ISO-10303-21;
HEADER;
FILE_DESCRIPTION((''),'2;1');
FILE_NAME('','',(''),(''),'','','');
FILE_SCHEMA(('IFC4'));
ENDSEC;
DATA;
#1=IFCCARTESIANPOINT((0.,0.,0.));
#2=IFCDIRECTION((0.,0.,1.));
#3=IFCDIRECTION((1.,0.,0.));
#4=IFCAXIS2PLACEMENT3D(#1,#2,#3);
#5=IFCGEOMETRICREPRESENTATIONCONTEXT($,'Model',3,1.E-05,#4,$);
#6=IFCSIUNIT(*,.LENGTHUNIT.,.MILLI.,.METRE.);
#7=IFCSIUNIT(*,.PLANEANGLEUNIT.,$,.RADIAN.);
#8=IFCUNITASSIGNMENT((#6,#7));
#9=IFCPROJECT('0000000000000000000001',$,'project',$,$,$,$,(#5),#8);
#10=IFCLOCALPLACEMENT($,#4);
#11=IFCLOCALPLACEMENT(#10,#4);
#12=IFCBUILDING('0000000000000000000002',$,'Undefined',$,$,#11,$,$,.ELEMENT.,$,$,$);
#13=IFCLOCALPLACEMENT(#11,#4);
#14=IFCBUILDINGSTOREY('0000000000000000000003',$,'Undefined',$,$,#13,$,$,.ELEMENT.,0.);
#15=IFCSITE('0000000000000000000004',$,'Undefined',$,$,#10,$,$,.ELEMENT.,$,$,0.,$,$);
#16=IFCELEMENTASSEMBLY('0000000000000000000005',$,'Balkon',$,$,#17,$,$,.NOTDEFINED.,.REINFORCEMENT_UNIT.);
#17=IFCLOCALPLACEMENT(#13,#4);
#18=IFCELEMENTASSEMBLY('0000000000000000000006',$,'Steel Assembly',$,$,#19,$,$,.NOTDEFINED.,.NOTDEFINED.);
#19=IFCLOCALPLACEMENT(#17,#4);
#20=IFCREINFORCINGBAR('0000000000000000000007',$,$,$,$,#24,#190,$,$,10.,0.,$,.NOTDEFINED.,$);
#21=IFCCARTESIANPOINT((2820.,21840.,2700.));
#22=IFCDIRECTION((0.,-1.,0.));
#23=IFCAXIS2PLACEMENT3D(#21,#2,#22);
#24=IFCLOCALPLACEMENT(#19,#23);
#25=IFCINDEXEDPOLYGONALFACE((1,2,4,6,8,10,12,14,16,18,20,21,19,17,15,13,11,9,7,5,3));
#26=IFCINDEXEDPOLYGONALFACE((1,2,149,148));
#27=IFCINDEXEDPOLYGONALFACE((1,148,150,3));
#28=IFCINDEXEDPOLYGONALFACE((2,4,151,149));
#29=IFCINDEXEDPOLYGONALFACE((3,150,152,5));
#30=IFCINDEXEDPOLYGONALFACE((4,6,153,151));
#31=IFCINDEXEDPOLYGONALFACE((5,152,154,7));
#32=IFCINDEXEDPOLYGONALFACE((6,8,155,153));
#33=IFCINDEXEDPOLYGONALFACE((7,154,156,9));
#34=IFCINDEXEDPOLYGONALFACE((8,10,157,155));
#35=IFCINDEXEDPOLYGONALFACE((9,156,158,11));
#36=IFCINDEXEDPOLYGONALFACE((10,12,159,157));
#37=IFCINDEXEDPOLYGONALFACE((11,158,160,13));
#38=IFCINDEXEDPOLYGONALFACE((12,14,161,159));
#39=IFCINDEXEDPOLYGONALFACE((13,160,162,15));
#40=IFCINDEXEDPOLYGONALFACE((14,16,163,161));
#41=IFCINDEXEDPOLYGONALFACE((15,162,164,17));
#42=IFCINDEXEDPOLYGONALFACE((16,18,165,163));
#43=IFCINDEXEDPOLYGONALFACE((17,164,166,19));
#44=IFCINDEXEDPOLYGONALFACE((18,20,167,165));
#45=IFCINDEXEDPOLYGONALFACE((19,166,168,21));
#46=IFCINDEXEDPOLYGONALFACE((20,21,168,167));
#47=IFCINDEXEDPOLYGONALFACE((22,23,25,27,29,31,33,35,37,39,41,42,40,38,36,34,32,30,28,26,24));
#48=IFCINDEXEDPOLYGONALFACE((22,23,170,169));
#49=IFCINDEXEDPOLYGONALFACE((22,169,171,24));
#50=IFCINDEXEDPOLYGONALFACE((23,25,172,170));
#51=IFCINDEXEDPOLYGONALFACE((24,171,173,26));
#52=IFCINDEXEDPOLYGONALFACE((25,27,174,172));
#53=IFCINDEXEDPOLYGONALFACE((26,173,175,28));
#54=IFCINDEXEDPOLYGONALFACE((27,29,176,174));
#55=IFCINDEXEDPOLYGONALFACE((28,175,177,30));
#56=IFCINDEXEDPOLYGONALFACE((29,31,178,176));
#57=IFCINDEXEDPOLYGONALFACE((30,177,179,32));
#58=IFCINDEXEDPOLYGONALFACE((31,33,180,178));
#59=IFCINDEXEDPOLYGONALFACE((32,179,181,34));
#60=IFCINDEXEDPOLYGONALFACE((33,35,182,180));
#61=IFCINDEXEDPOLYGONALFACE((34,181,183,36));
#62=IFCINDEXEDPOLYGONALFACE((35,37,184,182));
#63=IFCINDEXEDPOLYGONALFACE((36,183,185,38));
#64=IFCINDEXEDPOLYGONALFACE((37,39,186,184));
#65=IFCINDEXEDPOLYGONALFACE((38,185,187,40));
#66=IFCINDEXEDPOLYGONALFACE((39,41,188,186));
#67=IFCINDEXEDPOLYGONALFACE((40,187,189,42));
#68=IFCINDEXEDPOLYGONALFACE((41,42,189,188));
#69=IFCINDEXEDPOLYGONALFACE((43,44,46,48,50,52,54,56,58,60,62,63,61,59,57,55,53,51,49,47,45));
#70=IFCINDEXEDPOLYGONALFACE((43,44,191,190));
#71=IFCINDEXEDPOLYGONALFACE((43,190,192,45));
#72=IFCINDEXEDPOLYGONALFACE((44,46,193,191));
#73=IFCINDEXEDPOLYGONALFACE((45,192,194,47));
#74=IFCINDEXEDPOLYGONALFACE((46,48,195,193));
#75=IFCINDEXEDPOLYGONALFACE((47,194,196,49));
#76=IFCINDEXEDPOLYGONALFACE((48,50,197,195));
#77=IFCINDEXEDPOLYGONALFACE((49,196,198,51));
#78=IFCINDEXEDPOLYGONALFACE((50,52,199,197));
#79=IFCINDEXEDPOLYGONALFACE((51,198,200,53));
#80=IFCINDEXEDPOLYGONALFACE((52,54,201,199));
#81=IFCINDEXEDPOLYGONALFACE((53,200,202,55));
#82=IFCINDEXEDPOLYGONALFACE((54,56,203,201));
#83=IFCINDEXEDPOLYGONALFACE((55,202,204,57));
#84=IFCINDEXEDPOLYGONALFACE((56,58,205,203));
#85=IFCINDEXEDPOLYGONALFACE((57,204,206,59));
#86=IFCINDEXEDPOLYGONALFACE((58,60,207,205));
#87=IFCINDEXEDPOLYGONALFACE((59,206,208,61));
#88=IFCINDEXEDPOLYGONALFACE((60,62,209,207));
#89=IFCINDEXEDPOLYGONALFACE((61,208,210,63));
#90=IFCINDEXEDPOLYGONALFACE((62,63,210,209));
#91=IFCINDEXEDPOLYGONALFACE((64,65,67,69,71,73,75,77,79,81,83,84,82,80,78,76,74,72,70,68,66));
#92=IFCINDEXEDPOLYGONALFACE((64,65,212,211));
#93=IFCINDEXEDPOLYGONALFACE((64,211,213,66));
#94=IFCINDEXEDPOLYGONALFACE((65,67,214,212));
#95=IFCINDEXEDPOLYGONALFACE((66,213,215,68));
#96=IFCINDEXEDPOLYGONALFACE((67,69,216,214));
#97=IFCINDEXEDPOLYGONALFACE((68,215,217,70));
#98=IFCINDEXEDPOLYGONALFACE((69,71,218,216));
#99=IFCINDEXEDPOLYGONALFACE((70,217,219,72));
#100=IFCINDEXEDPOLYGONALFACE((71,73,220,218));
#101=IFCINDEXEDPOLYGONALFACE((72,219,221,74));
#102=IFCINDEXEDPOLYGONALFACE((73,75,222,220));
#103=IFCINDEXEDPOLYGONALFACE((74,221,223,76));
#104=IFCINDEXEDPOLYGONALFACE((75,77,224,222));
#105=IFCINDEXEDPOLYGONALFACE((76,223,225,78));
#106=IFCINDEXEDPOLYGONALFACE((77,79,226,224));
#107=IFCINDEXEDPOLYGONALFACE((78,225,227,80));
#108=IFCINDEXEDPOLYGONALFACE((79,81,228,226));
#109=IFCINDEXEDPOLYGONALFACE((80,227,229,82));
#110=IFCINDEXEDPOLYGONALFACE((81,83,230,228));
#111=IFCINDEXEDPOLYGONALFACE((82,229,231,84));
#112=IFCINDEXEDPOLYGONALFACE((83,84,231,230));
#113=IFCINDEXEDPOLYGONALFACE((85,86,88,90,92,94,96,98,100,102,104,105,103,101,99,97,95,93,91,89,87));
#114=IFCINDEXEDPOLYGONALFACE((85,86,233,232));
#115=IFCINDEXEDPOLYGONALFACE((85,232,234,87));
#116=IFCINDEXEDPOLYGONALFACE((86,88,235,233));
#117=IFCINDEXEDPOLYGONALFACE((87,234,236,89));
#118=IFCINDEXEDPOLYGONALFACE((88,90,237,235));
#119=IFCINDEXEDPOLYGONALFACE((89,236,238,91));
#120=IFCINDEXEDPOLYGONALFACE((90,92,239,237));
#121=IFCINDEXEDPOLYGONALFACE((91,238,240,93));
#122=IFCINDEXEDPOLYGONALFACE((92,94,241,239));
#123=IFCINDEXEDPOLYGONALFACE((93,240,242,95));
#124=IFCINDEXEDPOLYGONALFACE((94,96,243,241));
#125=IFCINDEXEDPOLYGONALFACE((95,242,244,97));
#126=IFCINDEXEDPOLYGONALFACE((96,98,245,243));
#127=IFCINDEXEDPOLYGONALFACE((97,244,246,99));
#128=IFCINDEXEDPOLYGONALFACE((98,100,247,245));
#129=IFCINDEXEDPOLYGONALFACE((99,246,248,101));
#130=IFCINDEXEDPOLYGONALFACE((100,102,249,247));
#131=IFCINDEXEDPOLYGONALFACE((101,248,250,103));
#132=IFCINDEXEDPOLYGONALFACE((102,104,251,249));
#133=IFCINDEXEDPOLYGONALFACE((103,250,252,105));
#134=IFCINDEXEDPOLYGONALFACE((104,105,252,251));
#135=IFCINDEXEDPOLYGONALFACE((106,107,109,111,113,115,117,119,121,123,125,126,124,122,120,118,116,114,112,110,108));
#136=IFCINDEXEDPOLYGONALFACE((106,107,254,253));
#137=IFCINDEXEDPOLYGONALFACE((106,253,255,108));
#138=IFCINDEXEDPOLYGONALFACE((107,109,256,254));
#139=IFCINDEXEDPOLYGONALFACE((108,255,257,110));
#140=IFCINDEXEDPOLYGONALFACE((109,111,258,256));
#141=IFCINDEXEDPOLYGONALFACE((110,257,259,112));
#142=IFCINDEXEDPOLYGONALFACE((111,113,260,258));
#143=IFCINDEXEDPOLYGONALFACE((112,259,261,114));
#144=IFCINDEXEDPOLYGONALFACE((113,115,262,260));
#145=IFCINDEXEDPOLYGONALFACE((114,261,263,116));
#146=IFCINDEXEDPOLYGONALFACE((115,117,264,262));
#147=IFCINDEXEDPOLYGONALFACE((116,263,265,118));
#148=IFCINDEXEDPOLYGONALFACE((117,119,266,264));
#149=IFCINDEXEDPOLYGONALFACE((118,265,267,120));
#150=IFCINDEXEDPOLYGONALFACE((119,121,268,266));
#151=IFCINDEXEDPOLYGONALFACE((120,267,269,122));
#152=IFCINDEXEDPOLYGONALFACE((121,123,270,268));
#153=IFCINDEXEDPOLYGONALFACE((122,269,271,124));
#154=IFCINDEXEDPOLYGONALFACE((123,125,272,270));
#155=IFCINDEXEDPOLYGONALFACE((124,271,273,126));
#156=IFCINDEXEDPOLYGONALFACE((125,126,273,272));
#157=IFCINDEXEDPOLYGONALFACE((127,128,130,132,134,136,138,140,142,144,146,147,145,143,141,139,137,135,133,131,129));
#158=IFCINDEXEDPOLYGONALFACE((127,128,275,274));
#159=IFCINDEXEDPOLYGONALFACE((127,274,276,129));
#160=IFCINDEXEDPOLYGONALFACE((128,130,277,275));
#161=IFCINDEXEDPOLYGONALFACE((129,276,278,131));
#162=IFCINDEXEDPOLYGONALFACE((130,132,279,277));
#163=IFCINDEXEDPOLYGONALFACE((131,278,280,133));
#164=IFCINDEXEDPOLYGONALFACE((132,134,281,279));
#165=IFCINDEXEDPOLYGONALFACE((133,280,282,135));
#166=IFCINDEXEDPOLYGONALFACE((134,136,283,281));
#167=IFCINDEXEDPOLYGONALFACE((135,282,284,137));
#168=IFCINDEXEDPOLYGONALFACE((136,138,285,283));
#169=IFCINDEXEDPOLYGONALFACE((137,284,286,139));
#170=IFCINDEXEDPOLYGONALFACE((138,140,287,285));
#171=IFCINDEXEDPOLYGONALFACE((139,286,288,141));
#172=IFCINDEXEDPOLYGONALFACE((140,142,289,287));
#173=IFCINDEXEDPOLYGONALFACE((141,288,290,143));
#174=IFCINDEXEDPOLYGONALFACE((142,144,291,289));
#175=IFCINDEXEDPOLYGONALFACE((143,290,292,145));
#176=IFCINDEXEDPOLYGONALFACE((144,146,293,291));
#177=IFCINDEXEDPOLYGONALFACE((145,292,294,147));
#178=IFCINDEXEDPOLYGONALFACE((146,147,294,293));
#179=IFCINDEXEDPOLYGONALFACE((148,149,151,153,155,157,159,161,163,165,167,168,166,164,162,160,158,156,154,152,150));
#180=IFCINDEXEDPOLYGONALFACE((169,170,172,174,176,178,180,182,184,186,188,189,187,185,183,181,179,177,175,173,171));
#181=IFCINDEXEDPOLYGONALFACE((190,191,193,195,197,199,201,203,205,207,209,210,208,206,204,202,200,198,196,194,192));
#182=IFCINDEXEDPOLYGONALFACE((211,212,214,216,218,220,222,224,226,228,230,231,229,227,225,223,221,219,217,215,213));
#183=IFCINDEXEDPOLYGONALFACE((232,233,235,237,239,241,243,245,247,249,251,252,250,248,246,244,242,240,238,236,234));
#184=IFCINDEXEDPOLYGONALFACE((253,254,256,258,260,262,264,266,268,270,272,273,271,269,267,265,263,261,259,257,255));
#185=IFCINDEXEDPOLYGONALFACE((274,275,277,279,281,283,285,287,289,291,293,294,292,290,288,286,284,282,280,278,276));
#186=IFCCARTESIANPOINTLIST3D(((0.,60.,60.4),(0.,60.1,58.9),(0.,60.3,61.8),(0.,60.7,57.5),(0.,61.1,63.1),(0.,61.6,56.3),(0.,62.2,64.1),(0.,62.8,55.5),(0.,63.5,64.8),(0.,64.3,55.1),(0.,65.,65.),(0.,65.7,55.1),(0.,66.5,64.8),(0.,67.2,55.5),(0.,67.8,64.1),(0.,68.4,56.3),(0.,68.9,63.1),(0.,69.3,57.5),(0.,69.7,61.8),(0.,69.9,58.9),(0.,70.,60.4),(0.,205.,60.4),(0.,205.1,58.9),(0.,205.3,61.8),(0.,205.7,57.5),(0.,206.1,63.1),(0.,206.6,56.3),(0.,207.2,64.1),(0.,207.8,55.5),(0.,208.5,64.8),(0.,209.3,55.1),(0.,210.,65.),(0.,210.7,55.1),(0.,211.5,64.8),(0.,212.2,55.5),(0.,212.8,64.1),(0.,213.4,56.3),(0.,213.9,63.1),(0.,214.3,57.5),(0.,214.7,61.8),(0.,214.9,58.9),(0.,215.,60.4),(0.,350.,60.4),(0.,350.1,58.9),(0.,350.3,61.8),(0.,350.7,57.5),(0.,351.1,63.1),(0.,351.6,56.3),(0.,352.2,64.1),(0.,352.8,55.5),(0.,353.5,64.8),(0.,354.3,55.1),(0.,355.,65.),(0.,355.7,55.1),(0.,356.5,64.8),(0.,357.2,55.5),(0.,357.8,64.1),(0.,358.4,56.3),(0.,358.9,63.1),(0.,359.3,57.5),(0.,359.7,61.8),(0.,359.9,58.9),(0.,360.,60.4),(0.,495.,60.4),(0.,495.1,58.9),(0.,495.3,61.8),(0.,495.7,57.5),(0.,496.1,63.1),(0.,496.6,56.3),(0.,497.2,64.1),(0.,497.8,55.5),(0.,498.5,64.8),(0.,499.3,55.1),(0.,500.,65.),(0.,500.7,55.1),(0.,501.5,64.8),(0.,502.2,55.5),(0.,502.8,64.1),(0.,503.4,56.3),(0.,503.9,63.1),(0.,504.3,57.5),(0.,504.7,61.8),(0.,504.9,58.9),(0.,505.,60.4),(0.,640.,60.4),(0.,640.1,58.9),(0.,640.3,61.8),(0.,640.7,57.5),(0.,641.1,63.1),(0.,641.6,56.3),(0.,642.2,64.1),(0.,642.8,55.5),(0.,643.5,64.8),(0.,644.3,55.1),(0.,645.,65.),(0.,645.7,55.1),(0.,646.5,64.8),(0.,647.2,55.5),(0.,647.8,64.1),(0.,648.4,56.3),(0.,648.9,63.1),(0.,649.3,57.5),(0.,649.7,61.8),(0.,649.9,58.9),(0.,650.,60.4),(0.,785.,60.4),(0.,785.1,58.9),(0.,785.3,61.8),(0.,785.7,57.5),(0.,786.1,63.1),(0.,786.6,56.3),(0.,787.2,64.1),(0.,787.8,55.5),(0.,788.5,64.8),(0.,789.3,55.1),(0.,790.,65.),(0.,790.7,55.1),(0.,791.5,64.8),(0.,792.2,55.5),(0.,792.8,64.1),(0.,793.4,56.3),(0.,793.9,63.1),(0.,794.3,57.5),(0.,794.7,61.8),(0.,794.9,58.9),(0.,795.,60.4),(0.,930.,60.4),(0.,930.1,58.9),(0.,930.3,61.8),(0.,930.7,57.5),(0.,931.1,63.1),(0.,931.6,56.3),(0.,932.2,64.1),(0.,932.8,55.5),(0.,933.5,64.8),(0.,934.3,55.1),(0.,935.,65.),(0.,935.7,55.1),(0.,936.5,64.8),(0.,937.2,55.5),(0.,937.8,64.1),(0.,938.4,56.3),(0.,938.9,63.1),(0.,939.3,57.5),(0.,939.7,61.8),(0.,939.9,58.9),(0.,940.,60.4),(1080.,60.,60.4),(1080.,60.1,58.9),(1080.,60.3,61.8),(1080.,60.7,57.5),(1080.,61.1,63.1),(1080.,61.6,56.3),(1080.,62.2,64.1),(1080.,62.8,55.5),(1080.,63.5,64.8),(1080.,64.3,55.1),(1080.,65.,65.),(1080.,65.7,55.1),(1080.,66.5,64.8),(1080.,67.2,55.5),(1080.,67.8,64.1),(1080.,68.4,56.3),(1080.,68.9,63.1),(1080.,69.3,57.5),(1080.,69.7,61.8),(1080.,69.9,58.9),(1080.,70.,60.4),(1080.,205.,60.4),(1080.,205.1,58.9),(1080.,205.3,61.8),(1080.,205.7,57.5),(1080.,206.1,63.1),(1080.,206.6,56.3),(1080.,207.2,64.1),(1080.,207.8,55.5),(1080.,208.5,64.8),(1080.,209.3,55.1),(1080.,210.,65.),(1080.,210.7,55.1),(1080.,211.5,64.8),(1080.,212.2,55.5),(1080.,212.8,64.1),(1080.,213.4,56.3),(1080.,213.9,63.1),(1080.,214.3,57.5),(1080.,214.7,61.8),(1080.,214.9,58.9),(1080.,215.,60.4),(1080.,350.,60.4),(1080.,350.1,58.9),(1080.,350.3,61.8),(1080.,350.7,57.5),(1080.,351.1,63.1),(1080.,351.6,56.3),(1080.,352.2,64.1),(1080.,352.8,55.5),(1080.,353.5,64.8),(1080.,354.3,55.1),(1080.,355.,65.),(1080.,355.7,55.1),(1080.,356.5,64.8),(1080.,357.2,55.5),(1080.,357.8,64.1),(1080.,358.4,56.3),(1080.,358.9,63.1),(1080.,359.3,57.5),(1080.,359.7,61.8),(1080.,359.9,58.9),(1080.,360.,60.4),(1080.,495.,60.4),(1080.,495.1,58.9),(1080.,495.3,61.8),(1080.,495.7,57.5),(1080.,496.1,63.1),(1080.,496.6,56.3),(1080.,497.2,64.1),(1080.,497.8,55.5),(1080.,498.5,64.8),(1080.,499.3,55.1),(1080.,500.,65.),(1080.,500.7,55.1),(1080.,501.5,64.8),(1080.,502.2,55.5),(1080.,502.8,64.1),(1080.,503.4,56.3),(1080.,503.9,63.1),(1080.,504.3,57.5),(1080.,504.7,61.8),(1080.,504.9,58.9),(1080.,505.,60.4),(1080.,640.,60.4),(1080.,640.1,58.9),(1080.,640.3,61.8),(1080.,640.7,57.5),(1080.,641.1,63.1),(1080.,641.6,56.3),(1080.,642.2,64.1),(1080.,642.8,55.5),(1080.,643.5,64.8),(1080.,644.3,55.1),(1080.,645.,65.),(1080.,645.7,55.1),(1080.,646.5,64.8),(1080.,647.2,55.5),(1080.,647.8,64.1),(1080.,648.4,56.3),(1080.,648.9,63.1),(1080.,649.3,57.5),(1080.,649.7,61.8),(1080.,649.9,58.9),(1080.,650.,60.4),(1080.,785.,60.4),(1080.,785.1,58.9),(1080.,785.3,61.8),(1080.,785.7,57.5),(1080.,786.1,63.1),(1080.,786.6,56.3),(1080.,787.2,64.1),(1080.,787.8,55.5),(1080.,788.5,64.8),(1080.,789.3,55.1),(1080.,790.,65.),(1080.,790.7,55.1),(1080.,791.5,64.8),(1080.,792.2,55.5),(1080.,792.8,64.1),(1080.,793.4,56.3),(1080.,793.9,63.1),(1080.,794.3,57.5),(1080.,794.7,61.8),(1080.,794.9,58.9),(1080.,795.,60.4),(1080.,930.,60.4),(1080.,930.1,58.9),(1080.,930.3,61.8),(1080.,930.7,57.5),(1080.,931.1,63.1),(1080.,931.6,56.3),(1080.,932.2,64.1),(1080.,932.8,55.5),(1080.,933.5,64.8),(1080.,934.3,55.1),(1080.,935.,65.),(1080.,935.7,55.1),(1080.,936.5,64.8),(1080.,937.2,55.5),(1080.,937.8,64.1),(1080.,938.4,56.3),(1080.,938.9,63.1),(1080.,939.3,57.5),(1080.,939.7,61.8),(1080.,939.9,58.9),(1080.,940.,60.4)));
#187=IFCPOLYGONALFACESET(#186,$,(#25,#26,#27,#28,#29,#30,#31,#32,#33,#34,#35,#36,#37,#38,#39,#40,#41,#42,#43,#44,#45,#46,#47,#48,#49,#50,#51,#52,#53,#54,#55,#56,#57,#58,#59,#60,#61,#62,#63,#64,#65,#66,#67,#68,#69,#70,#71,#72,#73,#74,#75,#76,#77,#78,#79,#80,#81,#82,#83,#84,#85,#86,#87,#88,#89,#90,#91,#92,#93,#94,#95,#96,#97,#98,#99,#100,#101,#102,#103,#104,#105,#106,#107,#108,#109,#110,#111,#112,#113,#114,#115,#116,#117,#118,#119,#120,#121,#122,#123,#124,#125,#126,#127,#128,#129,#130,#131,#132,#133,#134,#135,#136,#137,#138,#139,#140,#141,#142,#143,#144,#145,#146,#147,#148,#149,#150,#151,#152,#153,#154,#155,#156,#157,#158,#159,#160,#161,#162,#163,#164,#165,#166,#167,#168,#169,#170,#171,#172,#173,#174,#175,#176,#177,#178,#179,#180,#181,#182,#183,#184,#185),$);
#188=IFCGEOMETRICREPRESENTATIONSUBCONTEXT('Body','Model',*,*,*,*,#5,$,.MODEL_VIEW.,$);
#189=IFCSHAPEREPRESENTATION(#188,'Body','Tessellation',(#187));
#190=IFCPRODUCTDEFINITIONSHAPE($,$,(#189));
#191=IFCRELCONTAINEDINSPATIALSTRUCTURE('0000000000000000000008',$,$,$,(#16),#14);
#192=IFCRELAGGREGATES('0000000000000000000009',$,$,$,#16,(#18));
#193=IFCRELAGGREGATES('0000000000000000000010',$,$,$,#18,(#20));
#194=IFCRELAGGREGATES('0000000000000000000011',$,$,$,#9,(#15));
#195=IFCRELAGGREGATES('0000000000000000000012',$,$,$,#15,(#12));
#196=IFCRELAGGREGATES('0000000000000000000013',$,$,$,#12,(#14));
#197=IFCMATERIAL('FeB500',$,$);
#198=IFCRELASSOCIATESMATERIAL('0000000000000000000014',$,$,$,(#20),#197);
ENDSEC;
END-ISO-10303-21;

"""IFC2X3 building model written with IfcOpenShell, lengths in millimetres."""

from ifc_helpers import new_model, entity, si_unit, frame, origin_with_axes, place, context, subcontext, project, spatial, source, transform, mapped, material, element, aggregate, save


model = new_model("IFC2X3")

# Units and contexts
model_context = context("Model", 3, precision=1e-05, world=origin_with_axes())
body_context = subcontext(model_context, "Body", "Model", "MODEL_VIEW")
ifc_project = project(units=[si_unit("LENGTHUNIT", "METRE", prefix="MILLI"), si_unit("PLANEANGLEUNIT", "RADIAN")], contexts=[model_context])

# Site, building, storey
site_placement = place(None, origin_with_axes())
site = spatial("IfcSite", under=ifc_project, at=site_placement, Name="Undefined", CompositionType="ELEMENT", RefElevation=0.0)
building_placement = place(site_placement, origin_with_axes())
building = spatial("IfcBuilding", under=site, at=building_placement, Name="Undefined", CompositionType="ELEMENT")
storey_placement = place(building_placement, origin_with_axes())
storey = spatial("IfcBuildingStorey", under=building, at=storey_placement, Name="Undefined", CompositionType="ELEMENT", Elevation=0.0)

# Element assemblies, reinforcing bar
assembly_1_placement = place(storey_placement, origin_with_axes())
assembly_1 = element("IfcElementAssembly", 1, at=assembly_1_placement, inside=storey, Name="Balkon", AssemblyPlace="NOTDEFINED", PredefinedType="REINFORCEMENT_UNIT")
ifc_material_1 = material(Name="FeB500")
assembly_2_placement = place(assembly_1_placement, origin_with_axes())
assembly_2 = element("IfcElementAssembly", 2, at=assembly_2_placement, Name="Steel Assembly", AssemblyPlace="NOTDEFINED", PredefinedType="NOTDEFINED")
aggregate(assembly_1, [assembly_2])
shared_shape_1 = source(origin_with_axes(), body_context, "Body", "AdvancedSweptSolid", [
    entity("IfcSweptDiskSolid", entity("IfcTrimmedCurve", entity("IfcLine", entity("IfcCartesianPoint", [0.0, 0.0, 0.0]), entity("IfcVector", entity("IfcDirection", [1.0, 0.0, 0.0]), 1.0)), [entity("IfcParameterValue", 0.0)], [entity("IfcParameterValue", 1080.0)], True, "PARAMETER"), 5.0, None, 0.0, 1080.0),
])
shared_shape_2 = source(origin_with_axes(), body_context, "Body", "AdvancedSweptSolid", [
    entity("IfcSweptDiskSolid", entity("IfcTrimmedCurve", entity("IfcLine", entity("IfcCartesianPoint", [0.0, 0.0, 0.0]), entity("IfcVector", entity("IfcDirection", [1.0, 0.0, 0.0]), 1.0)), [entity("IfcParameterValue", 0.0)], [entity("IfcParameterValue", 1080.0)], True, "PARAMETER"), 5.0, None, 0.0, 1080.0),
])
shared_shape_3 = source(origin_with_axes(), body_context, "Body", "AdvancedSweptSolid", [
    entity("IfcSweptDiskSolid", entity("IfcTrimmedCurve", entity("IfcLine", entity("IfcCartesianPoint", [0.0, 0.0, 0.0]), entity("IfcVector", entity("IfcDirection", [1.0, 0.0, 0.0]), 1.0)), [entity("IfcParameterValue", 0.0)], [entity("IfcParameterValue", 1080.0)], True, "PARAMETER"), 5.0, None, 0.0, 1080.0),
])
shared_shape_4 = source(origin_with_axes(), body_context, "Body", "AdvancedSweptSolid", [
    entity("IfcSweptDiskSolid", entity("IfcTrimmedCurve", entity("IfcLine", entity("IfcCartesianPoint", [0.0, 0.0, 0.0]), entity("IfcVector", entity("IfcDirection", [1.0, 0.0, 0.0]), 1.0)), [entity("IfcParameterValue", 0.0)], [entity("IfcParameterValue", 1080.0)], True, "PARAMETER"), 5.0, None, 0.0, 1080.0),
])
shared_shape_5 = source(origin_with_axes(), body_context, "Body", "AdvancedSweptSolid", [
    entity("IfcSweptDiskSolid", entity("IfcTrimmedCurve", entity("IfcLine", entity("IfcCartesianPoint", [0.0, 0.0, 0.0]), entity("IfcVector", entity("IfcDirection", [1.0, 0.0, 0.0]), 1.0)), [entity("IfcParameterValue", 0.0)], [entity("IfcParameterValue", 1080.0)], True, "PARAMETER"), 5.0, None, 0.0, 1080.0),
])
shared_shape_6 = source(origin_with_axes(), body_context, "Body", "AdvancedSweptSolid", [
    entity("IfcSweptDiskSolid", entity("IfcTrimmedCurve", entity("IfcLine", entity("IfcCartesianPoint", [0.0, 0.0, 0.0]), entity("IfcVector", entity("IfcDirection", [1.0, 0.0, 0.0]), 1.0)), [entity("IfcParameterValue", 0.0)], [entity("IfcParameterValue", 1080.0)], True, "PARAMETER"), 5.0, None, 0.0, 1080.0),
])
shared_shape_7 = source(origin_with_axes(), body_context, "Body", "AdvancedSweptSolid", [
    entity("IfcSweptDiskSolid", entity("IfcTrimmedCurve", entity("IfcLine", entity("IfcCartesianPoint", [0.0, 0.0, 0.0]), entity("IfcVector", entity("IfcDirection", [1.0, 0.0, 0.0]), 1.0)), [entity("IfcParameterValue", 0.0)], [entity("IfcParameterValue", 1080.0)], True, "PARAMETER"), 5.0, None, 0.0, 1080.0),
])
reinforcing_bar_1_placement = place(assembly_2_placement, frame((2820.0, 21840.0, 2700.0), z_axis=(0.0, 0.0, 1.0), x_axis=(0.0, -1.0, 0.0)))
reinforcing_bar_1 = element("IfcReinforcingBar", 3, at=reinforcing_bar_1_placement, material=ifc_material_1, BarRole="NOTDEFINED", CrossSectionArea=0.0, NominalDiameter=10.0, context=body_context, shape_type="MappedRepresentation", body=[
    mapped(shared_shape_1, transform((0.0, 65.0, 60.0))),
    mapped(shared_shape_2, transform((0.0, 210.0, 60.0))),
    mapped(shared_shape_3, transform((0.0, 355.0, 60.0))),
    mapped(shared_shape_4, transform((0.0, 500.0, 60.0))),
    mapped(shared_shape_5, transform((0.0, 645.0, 60.0))),
    mapped(shared_shape_6, transform((0.0, 790.0, 60.0))),
    mapped(shared_shape_7, transform((0.0, 935.0, 60.0))),
])
aggregate(assembly_2, [reinforcing_bar_1])

save(model, "model.ifc")
